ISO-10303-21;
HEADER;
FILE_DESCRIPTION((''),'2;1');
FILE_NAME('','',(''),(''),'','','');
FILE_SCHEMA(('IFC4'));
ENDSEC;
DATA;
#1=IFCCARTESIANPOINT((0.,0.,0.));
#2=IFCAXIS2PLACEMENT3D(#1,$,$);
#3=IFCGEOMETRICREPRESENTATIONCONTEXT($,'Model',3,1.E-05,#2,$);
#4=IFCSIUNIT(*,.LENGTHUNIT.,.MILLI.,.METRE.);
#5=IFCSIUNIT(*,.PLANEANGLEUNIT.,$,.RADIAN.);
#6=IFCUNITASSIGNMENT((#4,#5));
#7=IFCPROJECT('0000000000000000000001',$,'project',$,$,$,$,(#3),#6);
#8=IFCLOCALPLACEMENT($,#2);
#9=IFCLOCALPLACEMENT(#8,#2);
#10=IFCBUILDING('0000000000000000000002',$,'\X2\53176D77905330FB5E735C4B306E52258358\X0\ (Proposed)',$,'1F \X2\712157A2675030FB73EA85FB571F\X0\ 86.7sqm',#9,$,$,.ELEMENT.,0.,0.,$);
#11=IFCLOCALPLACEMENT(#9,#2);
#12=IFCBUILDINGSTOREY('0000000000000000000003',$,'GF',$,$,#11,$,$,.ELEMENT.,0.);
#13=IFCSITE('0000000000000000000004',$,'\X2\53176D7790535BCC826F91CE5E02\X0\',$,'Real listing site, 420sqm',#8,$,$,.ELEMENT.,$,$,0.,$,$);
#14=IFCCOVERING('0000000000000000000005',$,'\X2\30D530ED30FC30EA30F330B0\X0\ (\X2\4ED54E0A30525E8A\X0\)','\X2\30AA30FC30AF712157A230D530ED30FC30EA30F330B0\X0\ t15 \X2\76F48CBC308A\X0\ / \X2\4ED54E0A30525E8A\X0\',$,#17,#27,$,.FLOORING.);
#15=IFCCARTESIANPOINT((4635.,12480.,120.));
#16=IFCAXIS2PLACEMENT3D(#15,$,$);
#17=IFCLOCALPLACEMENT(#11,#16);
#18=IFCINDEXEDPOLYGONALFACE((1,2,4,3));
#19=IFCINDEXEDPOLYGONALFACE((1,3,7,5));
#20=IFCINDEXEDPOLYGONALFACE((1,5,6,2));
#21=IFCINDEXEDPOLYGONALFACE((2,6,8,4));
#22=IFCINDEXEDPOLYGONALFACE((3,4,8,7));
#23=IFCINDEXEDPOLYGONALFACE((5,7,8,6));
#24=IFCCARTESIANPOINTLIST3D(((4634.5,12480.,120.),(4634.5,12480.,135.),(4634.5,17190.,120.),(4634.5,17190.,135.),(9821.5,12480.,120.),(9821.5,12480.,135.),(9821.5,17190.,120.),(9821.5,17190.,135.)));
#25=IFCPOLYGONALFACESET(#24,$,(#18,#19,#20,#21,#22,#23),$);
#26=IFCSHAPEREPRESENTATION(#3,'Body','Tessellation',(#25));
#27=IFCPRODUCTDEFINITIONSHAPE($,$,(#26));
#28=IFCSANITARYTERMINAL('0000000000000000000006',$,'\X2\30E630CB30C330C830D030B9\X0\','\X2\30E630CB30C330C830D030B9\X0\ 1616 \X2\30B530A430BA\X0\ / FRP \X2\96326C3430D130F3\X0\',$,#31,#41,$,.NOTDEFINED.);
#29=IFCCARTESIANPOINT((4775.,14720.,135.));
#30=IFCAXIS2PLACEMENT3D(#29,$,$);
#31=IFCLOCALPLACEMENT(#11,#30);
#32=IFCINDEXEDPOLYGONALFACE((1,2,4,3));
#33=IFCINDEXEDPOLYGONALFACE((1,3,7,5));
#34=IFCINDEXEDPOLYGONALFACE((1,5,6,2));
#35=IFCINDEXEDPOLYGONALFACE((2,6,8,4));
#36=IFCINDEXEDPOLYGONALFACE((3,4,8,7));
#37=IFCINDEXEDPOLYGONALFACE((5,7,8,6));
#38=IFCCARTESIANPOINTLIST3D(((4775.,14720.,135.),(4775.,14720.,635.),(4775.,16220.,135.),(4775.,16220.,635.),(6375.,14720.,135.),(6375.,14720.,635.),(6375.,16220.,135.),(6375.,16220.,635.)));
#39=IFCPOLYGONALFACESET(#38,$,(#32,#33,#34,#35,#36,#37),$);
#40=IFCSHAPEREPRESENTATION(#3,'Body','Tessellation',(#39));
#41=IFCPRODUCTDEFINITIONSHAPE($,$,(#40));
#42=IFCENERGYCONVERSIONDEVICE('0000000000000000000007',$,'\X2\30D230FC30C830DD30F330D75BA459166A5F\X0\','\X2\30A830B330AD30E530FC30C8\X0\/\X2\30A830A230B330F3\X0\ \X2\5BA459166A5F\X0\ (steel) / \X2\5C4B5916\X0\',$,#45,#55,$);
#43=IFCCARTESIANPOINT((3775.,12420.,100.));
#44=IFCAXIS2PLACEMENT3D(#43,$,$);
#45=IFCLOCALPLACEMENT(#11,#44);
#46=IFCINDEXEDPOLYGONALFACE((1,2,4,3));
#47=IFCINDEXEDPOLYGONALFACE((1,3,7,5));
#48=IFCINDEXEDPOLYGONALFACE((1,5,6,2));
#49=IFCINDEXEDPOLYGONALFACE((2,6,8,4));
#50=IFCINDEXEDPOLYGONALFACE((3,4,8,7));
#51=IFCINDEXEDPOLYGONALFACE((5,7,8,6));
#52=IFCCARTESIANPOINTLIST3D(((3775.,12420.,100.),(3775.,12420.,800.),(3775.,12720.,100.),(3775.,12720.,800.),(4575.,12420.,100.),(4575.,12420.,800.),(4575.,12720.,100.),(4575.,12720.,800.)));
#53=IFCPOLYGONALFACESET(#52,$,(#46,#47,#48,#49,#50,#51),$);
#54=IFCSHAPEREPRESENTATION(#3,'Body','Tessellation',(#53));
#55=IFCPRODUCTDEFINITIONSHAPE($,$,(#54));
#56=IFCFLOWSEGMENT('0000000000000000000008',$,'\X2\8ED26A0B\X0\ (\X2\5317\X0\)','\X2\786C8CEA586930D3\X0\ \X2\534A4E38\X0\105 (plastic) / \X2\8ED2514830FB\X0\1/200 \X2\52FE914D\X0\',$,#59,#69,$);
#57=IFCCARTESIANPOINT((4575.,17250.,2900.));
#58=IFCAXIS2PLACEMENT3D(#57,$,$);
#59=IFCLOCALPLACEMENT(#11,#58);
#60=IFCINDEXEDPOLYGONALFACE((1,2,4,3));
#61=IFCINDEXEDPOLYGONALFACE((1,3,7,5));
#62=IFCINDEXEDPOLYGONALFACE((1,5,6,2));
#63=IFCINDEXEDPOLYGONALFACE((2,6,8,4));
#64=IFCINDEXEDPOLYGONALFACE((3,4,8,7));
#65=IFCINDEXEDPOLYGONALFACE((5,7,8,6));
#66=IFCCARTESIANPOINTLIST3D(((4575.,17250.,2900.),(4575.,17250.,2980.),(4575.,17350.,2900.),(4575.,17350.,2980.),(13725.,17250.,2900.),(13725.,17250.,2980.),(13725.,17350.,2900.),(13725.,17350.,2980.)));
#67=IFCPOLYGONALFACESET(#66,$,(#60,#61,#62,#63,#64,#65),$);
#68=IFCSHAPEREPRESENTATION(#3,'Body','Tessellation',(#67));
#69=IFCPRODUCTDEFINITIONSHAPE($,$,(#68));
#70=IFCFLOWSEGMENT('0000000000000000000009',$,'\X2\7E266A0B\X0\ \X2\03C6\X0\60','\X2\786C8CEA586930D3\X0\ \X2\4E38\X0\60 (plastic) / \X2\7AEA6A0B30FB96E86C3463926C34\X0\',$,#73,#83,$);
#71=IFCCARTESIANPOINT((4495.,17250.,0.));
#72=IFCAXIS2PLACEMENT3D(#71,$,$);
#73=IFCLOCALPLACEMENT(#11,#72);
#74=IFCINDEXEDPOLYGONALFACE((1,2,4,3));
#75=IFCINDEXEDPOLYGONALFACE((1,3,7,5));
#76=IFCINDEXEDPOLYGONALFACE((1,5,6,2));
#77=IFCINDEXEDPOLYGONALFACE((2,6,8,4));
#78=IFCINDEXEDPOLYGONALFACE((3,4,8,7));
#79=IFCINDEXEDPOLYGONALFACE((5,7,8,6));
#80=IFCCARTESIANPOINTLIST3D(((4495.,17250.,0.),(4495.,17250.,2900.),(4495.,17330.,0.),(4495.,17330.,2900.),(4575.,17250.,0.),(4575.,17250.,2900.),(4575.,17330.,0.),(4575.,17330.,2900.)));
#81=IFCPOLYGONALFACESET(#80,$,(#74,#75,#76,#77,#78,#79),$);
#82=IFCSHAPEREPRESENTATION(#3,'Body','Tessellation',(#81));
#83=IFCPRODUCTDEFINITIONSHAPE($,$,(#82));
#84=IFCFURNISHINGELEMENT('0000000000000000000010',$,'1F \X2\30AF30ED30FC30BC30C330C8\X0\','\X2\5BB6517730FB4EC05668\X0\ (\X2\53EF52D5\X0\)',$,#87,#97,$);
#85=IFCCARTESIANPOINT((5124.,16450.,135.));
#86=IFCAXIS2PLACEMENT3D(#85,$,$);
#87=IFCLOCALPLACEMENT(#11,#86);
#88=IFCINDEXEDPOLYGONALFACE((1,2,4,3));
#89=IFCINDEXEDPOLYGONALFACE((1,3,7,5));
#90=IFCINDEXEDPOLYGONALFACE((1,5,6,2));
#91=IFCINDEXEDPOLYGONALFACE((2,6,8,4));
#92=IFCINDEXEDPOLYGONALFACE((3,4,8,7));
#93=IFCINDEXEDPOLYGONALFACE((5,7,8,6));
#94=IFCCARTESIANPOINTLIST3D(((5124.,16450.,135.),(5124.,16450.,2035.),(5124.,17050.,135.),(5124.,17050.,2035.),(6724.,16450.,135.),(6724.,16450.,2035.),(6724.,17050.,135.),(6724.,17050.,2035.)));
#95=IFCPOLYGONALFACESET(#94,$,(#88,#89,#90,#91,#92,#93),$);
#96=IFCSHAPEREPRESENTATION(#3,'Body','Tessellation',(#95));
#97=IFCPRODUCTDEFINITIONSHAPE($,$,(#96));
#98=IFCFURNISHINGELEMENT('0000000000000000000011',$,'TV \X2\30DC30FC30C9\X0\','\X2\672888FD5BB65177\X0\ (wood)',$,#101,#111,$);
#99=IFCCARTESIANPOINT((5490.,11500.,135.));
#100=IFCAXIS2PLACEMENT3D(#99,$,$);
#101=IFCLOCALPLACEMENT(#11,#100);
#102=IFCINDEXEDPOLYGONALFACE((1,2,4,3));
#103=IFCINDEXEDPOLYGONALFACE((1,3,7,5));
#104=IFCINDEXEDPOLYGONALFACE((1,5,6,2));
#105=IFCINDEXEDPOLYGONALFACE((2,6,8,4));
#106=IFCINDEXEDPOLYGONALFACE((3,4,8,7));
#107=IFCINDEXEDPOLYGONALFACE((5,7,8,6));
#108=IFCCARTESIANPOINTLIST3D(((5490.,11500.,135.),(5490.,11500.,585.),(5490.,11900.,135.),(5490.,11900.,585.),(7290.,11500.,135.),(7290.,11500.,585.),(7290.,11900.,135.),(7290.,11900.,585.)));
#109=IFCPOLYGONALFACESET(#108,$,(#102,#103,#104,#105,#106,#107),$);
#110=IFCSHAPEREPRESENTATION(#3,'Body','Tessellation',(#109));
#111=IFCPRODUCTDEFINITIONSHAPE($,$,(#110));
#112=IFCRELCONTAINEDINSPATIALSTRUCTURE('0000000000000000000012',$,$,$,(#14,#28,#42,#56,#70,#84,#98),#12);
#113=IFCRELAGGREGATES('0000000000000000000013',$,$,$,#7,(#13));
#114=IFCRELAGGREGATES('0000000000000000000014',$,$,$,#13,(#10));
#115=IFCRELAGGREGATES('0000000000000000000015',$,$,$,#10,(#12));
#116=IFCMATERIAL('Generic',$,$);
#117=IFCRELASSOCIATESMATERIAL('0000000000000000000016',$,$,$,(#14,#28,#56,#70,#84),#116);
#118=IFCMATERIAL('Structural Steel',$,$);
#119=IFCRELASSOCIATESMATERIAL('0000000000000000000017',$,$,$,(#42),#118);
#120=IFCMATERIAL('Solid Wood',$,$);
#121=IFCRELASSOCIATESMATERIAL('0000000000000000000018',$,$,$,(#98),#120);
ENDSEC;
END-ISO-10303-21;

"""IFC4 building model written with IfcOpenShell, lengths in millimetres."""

from ifc_helpers import new_model, si_unit, frame, frame_2d, origin, place, context, project, spatial, rectangle, extrude, material, element, save


model = new_model("IFC4")

# Units and contexts
model_context = context("Model", 3, precision=1e-05, world=origin())
ifc_project = project(units=[si_unit("LENGTHUNIT", "METRE", prefix="MILLI"), si_unit("PLANEANGLEUNIT", "RADIAN")], contexts=[model_context])

# Site, building, storey
site_placement = place(None, origin())
site = spatial("IfcSite", under=ifc_project, at=site_placement, Name="北海道富良野市", ObjectType="Real listing site, 420sqm", CompositionType="ELEMENT", RefElevation=0.0)
building_placement = place(site_placement, origin())
building = spatial("IfcBuilding", under=site, at=building_placement, Name="北海道・平屋の別荘 (Proposed)", ObjectType="1F 無垢材・珪藻土 86.7sqm", CompositionType="ELEMENT", ElevationOfRefHeight=0.0, ElevationOfTerrain=0.0)
storey_placement = place(building_placement, origin())
storey = spatial("IfcBuildingStorey", under=building, at=storey_placement, Name="GF", CompositionType="ELEMENT", Elevation=0.0)

# Shared definitions
ifc_material_1 = material(Name="Solid Wood")

# Shared definitions
ifc_material_2 = material(Name="Structural Steel")

# Covering
ifc_material_3 = material(Name="Generic")
covering_placement = place(storey_placement, frame((4635.0, 12480.0, 120.0)))
element("IfcCovering", 1, at=covering_placement, inside=storey, material=ifc_material_3, Name="フローリング (仕上げ床)", Description="オーク無垢フローリング t15 直貼り / 仕上げ床", PredefinedType="FLOORING", context=model_context, shape_type="SweptSolid", body=[
    extrude(rectangle(XDim=5187.0, YDim=4710.0, at=frame_2d((2593.0, 2355.0))), frame((4635.0, 12480.0, 120.0)), (0.0, 0.0, 1.0), 15.0),
])

# Sanitary terminal
sanitary_terminal_placement = place(storey_placement, frame((4775.0, 14720.0, 135.0)))
element("IfcSanitaryTerminal", 2, at=sanitary_terminal_placement, inside=storey, material=ifc_material_3, Name="ユニットバス", Description="ユニットバス 1616 サイズ / FRP 防水パン", PredefinedType="NOTDEFINED", context=model_context, shape_type="SweptSolid", body=[
    extrude(rectangle(XDim=1600.0, YDim=1500.0, at=frame_2d((800.0, 750.0))), frame((4775.0, 14720.0, 135.0)), (0.0, 0.0, 1.0), 500.0),
])

# Energy conversion device
energy_conversion_device_placement = place(storey_placement, frame((3775.0, 12420.0, 100.0)))
element("IfcEnergyConversionDevice", 3, at=energy_conversion_device_placement, inside=storey, material=ifc_material_2, Name="ヒートポンプ室外機", Description="エコキュート/エアコン 室外機 (steel) / 屋外", context=model_context, shape_type="SweptSolid", body=[
    extrude(rectangle(XDim=800.0, YDim=300.0, at=frame_2d((400.0, 150.0))), frame((3775.0, 12420.0, 100.0)), (0.0, 0.0, 1.0), 700.0),
])

# Flow segments
flow_segment_1_placement = place(storey_placement, frame((4575.0, 17250.0, 2900.0)))
element("IfcFlowSegment", 4, at=flow_segment_1_placement, inside=storey, material=ifc_material_3, Name="軒樋 (北)", Description="硬質塩ビ 半丸105 (plastic) / 軒先・1/200 勾配", context=model_context, shape_type="SweptSolid", body=[
    extrude(rectangle(XDim=9150.0, YDim=100.0, at=frame_2d((4575.0, 50.0))), frame((4575.0, 17250.0, 2900.0)), (0.0, 0.0, 1.0), 80.0),
])
flow_segment_2_placement = place(storey_placement, frame((4495.0, 17250.0, 0.0)))
element("IfcFlowSegment", 5, at=flow_segment_2_placement, inside=storey, material=ifc_material_3, Name="縦樋 φ60", Description="硬質塩ビ 丸60 (plastic) / 竪樋・雨水排水", context=model_context, shape_type="SweptSolid", body=[
    extrude(rectangle(XDim=80.0, YDim=80.0, at=frame_2d((40.0, 40.0))), frame((4495.0, 17250.0, 0.0)), (0.0, 0.0, 1.0), 2900.0),
])

# Furnishing elements
furnishing_1_placement = place(storey_placement, frame((5124.0, 16450.0, 135.0)))
element("IfcFurnishingElement", 6, at=furnishing_1_placement, inside=storey, material=ifc_material_3, Name="1F クローゼット", Description="家具・什器 (可動)", context=model_context, shape_type="SweptSolid", body=[
    extrude(rectangle(XDim=1600.0, YDim=600.0, at=frame_2d((800.0, 300.0))), frame((5124.0, 16450.0, 135.0)), (0.0, 0.0, 1.0), 1900.0),
])
furnishing_2_placement = place(storey_placement, frame((5490.0, 11500.0, 135.0)))
element("IfcFurnishingElement", 7, at=furnishing_2_placement, inside=storey, material=ifc_material_1, Name="TV ボード", Description="木製家具 (wood)", context=model_context, shape_type="SweptSolid", body=[
    extrude(rectangle(XDim=1800.0, YDim=400.0, at=frame_2d((900.0, 200.0))), frame((5490.0, 11500.0, 135.0)), (0.0, 0.0, 1.0), 450.0),
])

save(model, "model.ifc")
